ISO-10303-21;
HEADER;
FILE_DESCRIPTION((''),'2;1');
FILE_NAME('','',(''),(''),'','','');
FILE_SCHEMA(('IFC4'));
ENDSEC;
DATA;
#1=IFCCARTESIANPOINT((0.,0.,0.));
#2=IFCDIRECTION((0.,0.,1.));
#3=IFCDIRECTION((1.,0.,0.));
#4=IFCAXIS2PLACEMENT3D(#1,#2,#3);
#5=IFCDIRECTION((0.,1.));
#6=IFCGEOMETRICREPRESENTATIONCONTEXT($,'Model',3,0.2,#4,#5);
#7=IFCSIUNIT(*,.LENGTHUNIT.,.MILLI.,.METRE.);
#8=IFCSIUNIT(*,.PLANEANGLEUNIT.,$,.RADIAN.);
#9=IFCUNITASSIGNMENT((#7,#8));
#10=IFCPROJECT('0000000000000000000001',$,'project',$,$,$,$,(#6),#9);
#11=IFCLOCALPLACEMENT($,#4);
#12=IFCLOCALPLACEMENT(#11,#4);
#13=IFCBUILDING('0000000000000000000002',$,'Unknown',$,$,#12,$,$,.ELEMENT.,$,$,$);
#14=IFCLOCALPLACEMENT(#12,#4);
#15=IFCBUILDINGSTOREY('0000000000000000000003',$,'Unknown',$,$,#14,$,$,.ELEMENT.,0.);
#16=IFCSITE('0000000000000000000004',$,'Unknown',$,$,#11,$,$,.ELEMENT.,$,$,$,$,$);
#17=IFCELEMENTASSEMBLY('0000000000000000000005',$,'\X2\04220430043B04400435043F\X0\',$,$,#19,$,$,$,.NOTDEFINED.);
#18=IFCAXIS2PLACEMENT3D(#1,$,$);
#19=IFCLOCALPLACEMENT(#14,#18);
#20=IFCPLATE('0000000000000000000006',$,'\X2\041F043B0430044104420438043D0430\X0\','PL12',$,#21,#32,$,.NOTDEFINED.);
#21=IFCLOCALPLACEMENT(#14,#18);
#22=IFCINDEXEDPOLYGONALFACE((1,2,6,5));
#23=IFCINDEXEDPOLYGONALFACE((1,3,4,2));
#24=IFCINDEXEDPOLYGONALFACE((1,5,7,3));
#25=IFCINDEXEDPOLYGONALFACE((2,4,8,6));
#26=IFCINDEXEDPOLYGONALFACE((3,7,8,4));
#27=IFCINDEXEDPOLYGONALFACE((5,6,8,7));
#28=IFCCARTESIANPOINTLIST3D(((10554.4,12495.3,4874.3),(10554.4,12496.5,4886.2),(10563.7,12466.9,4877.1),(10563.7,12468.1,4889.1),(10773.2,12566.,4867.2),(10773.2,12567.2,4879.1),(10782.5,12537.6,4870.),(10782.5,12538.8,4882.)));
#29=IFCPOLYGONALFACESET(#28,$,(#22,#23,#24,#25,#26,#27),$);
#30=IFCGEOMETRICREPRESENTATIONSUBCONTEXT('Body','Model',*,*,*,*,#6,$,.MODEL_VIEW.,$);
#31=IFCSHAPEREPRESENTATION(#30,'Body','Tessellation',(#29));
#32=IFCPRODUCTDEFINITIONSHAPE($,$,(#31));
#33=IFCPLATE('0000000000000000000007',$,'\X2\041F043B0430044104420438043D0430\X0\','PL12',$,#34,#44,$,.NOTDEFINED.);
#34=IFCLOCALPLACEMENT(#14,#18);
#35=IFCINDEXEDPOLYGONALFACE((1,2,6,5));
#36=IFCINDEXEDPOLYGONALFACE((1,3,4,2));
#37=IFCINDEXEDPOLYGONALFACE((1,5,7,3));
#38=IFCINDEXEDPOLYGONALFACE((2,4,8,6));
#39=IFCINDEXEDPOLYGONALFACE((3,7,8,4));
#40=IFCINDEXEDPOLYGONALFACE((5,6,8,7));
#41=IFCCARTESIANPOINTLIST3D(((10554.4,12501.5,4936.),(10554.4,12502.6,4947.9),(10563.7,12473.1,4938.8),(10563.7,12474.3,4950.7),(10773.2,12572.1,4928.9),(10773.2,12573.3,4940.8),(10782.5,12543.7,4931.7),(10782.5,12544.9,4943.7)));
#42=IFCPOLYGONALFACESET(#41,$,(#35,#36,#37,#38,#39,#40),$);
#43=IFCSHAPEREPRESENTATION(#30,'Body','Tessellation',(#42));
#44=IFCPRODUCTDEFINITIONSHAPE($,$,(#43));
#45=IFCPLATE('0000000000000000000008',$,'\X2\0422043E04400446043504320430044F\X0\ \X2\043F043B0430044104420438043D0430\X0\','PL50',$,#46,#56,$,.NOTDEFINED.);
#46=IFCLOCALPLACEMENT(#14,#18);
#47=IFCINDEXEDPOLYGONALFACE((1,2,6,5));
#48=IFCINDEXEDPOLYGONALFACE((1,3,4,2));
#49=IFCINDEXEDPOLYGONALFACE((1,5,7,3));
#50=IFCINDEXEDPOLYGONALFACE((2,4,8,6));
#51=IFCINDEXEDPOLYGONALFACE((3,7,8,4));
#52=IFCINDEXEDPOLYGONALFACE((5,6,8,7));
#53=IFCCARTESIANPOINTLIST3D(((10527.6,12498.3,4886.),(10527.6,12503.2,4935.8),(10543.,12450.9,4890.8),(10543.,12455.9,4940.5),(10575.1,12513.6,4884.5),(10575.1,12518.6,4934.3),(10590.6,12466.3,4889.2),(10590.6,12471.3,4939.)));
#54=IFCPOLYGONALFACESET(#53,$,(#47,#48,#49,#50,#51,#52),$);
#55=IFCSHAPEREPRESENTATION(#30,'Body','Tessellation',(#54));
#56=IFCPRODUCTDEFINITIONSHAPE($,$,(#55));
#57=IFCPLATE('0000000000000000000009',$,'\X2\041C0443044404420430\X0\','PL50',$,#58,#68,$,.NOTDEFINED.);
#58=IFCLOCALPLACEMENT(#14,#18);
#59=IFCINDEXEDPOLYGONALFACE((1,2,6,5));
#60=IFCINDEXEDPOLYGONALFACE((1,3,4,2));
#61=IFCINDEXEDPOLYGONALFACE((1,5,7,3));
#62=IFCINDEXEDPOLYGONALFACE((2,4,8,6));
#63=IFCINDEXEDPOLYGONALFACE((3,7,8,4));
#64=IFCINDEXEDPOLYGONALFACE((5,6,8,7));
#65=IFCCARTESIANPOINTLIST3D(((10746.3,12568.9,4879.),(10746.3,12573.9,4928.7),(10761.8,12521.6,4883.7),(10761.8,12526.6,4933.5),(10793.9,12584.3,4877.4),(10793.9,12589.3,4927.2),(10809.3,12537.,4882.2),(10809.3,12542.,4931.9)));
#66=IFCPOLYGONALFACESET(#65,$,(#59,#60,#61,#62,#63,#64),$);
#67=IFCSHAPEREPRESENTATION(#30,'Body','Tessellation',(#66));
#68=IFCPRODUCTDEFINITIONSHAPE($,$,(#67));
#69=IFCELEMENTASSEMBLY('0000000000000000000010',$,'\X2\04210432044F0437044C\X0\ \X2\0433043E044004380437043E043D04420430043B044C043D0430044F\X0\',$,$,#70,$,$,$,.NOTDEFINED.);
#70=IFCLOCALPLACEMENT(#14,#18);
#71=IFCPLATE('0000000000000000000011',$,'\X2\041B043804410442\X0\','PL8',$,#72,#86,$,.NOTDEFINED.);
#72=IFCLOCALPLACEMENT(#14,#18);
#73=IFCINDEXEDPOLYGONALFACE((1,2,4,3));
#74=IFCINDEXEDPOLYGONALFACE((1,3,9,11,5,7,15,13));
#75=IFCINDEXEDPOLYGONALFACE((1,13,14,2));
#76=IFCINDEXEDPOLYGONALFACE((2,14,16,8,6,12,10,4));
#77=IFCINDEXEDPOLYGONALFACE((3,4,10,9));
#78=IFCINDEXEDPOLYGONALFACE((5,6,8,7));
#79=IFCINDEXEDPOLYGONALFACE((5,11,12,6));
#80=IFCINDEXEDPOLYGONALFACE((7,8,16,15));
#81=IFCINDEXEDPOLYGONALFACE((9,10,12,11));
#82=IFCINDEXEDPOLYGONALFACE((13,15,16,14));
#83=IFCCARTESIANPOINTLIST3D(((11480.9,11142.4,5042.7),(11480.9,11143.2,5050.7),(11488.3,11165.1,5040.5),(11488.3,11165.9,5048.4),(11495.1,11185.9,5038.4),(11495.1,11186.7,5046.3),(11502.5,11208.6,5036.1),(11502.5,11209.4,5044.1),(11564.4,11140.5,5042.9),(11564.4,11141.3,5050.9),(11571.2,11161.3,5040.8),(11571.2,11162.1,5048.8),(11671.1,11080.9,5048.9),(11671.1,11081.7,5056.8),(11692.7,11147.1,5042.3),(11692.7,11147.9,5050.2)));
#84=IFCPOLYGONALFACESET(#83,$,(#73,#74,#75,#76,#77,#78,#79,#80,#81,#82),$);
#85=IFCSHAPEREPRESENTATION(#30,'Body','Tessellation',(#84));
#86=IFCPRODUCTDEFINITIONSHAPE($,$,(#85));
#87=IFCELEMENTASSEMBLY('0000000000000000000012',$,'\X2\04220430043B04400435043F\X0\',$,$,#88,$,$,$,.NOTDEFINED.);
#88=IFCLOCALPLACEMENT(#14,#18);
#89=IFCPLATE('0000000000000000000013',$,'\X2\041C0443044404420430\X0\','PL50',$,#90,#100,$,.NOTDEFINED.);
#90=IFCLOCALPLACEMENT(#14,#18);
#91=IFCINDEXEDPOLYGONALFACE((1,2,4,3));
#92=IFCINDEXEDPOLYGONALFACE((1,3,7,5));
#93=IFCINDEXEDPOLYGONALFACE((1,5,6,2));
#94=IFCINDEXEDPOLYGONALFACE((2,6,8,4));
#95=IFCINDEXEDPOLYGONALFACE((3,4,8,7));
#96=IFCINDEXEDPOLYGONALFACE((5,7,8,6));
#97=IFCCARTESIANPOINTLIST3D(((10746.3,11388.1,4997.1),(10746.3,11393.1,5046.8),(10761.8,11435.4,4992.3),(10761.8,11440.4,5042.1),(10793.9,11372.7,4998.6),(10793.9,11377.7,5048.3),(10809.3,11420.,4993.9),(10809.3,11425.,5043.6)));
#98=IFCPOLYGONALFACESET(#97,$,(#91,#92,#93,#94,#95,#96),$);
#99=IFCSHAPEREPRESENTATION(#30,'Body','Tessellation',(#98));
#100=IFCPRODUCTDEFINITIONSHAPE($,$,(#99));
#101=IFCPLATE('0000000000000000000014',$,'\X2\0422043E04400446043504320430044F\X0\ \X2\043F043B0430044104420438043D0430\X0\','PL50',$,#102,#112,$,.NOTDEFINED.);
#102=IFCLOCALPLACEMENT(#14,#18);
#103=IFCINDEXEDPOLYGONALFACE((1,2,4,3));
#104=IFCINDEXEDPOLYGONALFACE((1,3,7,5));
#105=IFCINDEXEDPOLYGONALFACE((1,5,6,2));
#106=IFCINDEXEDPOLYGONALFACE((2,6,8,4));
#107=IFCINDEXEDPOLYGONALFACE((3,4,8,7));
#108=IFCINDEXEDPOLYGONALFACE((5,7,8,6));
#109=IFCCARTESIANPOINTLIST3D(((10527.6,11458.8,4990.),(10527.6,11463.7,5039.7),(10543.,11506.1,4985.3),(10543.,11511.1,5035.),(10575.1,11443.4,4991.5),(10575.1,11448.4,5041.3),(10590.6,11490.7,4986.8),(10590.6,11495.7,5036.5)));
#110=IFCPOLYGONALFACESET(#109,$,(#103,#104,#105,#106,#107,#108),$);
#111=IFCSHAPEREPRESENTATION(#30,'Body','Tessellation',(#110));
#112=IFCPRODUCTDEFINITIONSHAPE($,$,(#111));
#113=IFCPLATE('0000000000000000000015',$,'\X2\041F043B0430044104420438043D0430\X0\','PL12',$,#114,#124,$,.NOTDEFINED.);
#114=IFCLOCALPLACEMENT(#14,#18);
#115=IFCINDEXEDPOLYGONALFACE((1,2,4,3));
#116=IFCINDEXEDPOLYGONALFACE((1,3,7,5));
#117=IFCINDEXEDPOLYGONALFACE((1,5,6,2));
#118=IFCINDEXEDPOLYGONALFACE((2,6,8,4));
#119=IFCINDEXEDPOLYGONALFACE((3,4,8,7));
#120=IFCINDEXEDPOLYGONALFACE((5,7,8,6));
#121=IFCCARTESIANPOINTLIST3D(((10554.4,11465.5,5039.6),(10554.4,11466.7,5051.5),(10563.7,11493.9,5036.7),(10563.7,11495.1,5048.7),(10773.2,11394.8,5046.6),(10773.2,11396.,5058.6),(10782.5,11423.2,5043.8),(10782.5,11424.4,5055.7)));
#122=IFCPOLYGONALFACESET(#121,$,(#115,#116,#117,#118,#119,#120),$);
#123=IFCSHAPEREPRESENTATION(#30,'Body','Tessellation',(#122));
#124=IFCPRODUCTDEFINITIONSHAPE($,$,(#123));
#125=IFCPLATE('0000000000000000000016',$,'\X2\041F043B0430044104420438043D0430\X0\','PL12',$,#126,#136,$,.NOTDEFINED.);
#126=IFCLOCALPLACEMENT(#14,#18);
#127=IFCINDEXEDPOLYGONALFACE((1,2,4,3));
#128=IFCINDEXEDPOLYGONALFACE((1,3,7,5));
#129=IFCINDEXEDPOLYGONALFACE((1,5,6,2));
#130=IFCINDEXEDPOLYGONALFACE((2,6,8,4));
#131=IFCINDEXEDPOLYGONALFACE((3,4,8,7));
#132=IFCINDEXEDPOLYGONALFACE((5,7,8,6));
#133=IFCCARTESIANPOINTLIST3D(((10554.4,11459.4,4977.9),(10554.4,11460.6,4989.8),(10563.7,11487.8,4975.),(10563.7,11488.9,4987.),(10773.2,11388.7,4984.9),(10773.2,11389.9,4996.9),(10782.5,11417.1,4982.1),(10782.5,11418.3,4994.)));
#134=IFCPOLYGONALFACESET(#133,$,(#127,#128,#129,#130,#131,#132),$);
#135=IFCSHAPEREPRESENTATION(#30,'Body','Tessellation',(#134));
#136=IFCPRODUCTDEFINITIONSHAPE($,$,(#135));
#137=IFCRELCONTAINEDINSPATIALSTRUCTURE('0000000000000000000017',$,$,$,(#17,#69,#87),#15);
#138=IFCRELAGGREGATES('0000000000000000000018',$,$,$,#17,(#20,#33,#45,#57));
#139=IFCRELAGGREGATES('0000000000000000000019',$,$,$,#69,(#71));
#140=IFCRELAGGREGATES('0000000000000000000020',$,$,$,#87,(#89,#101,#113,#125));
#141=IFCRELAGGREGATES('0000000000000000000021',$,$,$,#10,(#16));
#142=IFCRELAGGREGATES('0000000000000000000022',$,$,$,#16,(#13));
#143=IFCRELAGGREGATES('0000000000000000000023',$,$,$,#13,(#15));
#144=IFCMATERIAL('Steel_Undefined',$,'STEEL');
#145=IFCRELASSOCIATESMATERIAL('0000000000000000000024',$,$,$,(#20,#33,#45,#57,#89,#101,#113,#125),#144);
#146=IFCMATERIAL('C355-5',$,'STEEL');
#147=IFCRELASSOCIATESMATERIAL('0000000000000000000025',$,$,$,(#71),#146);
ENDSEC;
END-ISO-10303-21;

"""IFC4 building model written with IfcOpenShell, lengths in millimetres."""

from ifc_helpers import new_model, si_unit, direction, frame, origin_with_axes, place, context, subcontext, project, spatial, line, indexed_curve, outline, extrude, material, element, aggregate, save


model = new_model("IFC4")

# Units and contexts
model_context = context("Model", 3, precision=0.2, world=origin_with_axes(), true_north=direction((0.0, 1.0)))
body_context = subcontext(model_context, "Body", "Model", "MODEL_VIEW")
ifc_project = project(units=[si_unit("LENGTHUNIT", "METRE", prefix="MILLI"), si_unit("PLANEANGLEUNIT", "RADIAN")], contexts=[model_context])

# Site, building, storey
site_placement = place(None, origin_with_axes())
site = spatial("IfcSite", under=ifc_project, at=site_placement, Name="Unknown", CompositionType="ELEMENT")
building_placement = place(site_placement, origin_with_axes())
building = spatial("IfcBuilding", under=site, at=building_placement, Name="Unknown", CompositionType="ELEMENT")
storey_placement = place(building_placement, origin_with_axes())
storey = spatial("IfcBuildingStorey", under=building, at=storey_placement, Name="Unknown", CompositionType="ELEMENT", Elevation=0.0)

# Shared definitions
ifc_material_1 = material(Name="C355-5", Category="STEEL")

# Shared definitions
ifc_material_2 = material(Name="Steel_Undefined", Category="STEEL")

# Element assembly, plates
assembly_1_placement = place(storey_placement, frame((10785.5, 12534.3, 4932.7), z_axis=(-0.951109, -0.307322, 0.030732), x_axis=(-0.308855, 0.946389, -0.094639)))
assembly_1 = element("IfcElementAssembly", 1, at=assembly_1_placement, inside=storey, Name="Талреп", PredefinedType="NOTDEFINED")
plate_1_placement = place(assembly_1_placement, frame((10.0, 56.0, 230.0), z_axis=(0.0, 1.0, 0.0), x_axis=(1.0, 0.0, 0.0)))
plate_1 = element("IfcPlate", 2, at=plate_1_placement, material=ifc_material_2, Name="Пластина", Description="PL12", PredefinedType="NOTDEFINED", context=body_context, shape_type="SolidModel", body=[
    extrude(outline(indexed_curve([(0.0, 0.0), (30.0, 0.0), (30.0, 230.0), (0.0, 230.0)], segments=[line(1, 2, 3, 4, 1)])), frame((0.0, 0.0, 6.0), z_axis=(0.0, 0.0, 1.0), x_axis=(1.0, 0.0, 0.0)), (0.0, 0.0, -1.0), 12.0),
])
plate_2_placement = place(assembly_1_placement, frame((10.0, -6.0, 230.0), z_axis=(0.0, 1.0, 0.0), x_axis=(1.0, 0.0, 0.0)))
plate_2 = element("IfcPlate", 3, at=plate_2_placement, material=ifc_material_2, Name="Пластина", Description="PL12", PredefinedType="NOTDEFINED", context=body_context, shape_type="SolidModel", body=[
    extrude(outline(indexed_curve([(0.0, 0.0), (30.0, 0.0), (30.0, 230.0), (0.0, 230.0)], segments=[line(1, 2, 3, 4, 1)])), frame((0.0, 0.0, 6.0), z_axis=(0.0, 0.0, 1.0), x_axis=(1.0, 0.0, 0.0)), (0.0, 0.0, -1.0), 12.0),
])
plate_3_placement = place(assembly_1_placement, frame((0.0, 0.0, 230.0), z_axis=(0.0, 0.0, 1.0), x_axis=(1.0, 0.0, 0.0)))
plate_3 = element("IfcPlate", 4, at=plate_3_placement, material=ifc_material_2, Name="Торцевая пластина", Description="PL50", PredefinedType="NOTDEFINED", context=body_context, shape_type="SolidModel", body=[
    extrude(outline(indexed_curve([(0.0, 0.0), (50.0, 0.0), (50.0, 50.0), (0.0, 50.0)], segments=[line(1, 2, 3, 4, 1)])), frame((0.0, 0.0, 25.0), z_axis=(0.0, 0.0, 1.0), x_axis=(1.0, 0.0, 0.0)), (0.0, 0.0, -1.0), 50.0),
])
plate_4_placement = place(assembly_1_placement, origin_with_axes())
plate_4 = element("IfcPlate", 5, at=plate_4_placement, material=ifc_material_2, Name="Муфта", Description="PL50", PredefinedType="NOTDEFINED", context=body_context, shape_type="SolidModel", body=[
    extrude(outline(indexed_curve([(0.0, 0.0), (50.0, 0.0), (50.0, 50.0), (0.0, 50.0)], segments=[line(1, 2, 3, 4, 1)])), frame((0.0, 0.0, 25.0), z_axis=(0.0, 0.0, 1.0), x_axis=(1.0, 0.0, 0.0)), (0.0, 0.0, -1.0), 50.0),
])
aggregate(assembly_1, [plate_1, plate_2, plate_3, plate_4])

# Element assembly, plate
assembly_2_placement = place(storey_placement, frame((10668.4, 11441.9, 5016.8), z_axis=(-0.308855, -0.946389, 0.094639), x_axis=(0.951109, -0.307322, 0.030732)))
assembly_2 = element("IfcElementAssembly", 6, at=assembly_2_placement, inside=storey, Name="Связь горизонтальная", PredefinedType="NOTDEFINED")
plate_5_placement = place(assembly_2_placement, frame((865.6, 0.0, -35.0), z_axis=(0.0, -1.0, 0.0), x_axis=(1.0, 0.0, 0.0)))
plate_5 = element("IfcPlate", 7, at=plate_5_placement, material=ifc_material_1, Name="Лист", Description="PL8", PredefinedType="NOTDEFINED", context=body_context, shape_type="SolidModel", body=[
    extrude(outline(indexed_curve([(0.0, 0.0), (200.0, 0.0), (200.0, 70.0), (0.0, 70.0), (0.0, 46.0), (80.0, 46.0), (80.0, 24.0), (0.0, 24.0)], segments=[line(1, 2, 3, 4, 5, 6, 7, 8, 1)])), frame((0.0, 0.0, 4.0), z_axis=(0.0, 0.0, 1.0), x_axis=(1.0, 0.0, 0.0)), (0.0, 0.0, -1.0), 8.0),
])
aggregate(assembly_2, [plate_5])

# Element assembly, plates
assembly_3_placement = place(storey_placement, frame((10770.1, 11385.4, 5047.6), z_axis=(-0.951109, 0.307322, -0.030732), x_axis=(0.308855, 0.946389, -0.094639)))
assembly_3 = element("IfcElementAssembly", 8, at=assembly_3_placement, inside=storey, Name="Талреп", PredefinedType="NOTDEFINED")
plate_6_placement = place(assembly_3_placement, origin_with_axes())
plate_6 = element("IfcPlate", 9, at=plate_6_placement, material=ifc_material_2, Name="Муфта", Description="PL50", PredefinedType="NOTDEFINED", context=body_context, shape_type="SolidModel", body=[
    extrude(outline(indexed_curve([(0.0, 0.0), (50.0, 0.0), (50.0, 50.0), (0.0, 50.0)], segments=[line(1, 2, 3, 4, 1)])), frame((0.0, 0.0, 25.0), z_axis=(0.0, 0.0, 1.0), x_axis=(1.0, 0.0, 0.0)), (0.0, 0.0, -1.0), 50.0),
])
plate_7_placement = place(assembly_3_placement, frame((0.0, 0.0, 230.0), z_axis=(0.0, 0.0, 1.0), x_axis=(1.0, 0.0, 0.0)))
plate_7 = element("IfcPlate", 10, at=plate_7_placement, material=ifc_material_2, Name="Торцевая пластина", Description="PL50", PredefinedType="NOTDEFINED", context=body_context, shape_type="SolidModel", body=[
    extrude(outline(indexed_curve([(0.0, 0.0), (50.0, 0.0), (50.0, 50.0), (0.0, 50.0)], segments=[line(1, 2, 3, 4, 1)])), frame((0.0, 0.0, 25.0), z_axis=(0.0, 0.0, 1.0), x_axis=(1.0, 0.0, 0.0)), (0.0, 0.0, -1.0), 50.0),
])
plate_8_placement = place(assembly_3_placement, frame((10.0, -6.0, 230.0), z_axis=(0.0, 1.0, 0.0), x_axis=(1.0, 0.0, 0.0)))
plate_8 = element("IfcPlate", 11, at=plate_8_placement, material=ifc_material_2, Name="Пластина", Description="PL12", PredefinedType="NOTDEFINED", context=body_context, shape_type="SolidModel", body=[
    extrude(outline(indexed_curve([(0.0, 0.0), (30.0, 0.0), (30.0, 230.0), (0.0, 230.0)], segments=[line(1, 2, 3, 4, 1)])), frame((0.0, 0.0, 6.0), z_axis=(0.0, 0.0, 1.0), x_axis=(1.0, 0.0, 0.0)), (0.0, 0.0, -1.0), 12.0),
])
plate_9_placement = place(assembly_3_placement, frame((10.0, 56.0, 230.0), z_axis=(0.0, 1.0, 0.0), x_axis=(1.0, 0.0, 0.0)))
plate_9 = element("IfcPlate", 12, at=plate_9_placement, material=ifc_material_2, Name="Пластина", Description="PL12", PredefinedType="NOTDEFINED", context=body_context, shape_type="SolidModel", body=[
    extrude(outline(indexed_curve([(0.0, 0.0), (30.0, 0.0), (30.0, 230.0), (0.0, 230.0)], segments=[line(1, 2, 3, 4, 1)])), frame((0.0, 0.0, 6.0), z_axis=(0.0, 0.0, 1.0), x_axis=(1.0, 0.0, 0.0)), (0.0, 0.0, -1.0), 12.0),
])
aggregate(assembly_3, [plate_6, plate_7, plate_8, plate_9])

save(model, "model.ifc")
